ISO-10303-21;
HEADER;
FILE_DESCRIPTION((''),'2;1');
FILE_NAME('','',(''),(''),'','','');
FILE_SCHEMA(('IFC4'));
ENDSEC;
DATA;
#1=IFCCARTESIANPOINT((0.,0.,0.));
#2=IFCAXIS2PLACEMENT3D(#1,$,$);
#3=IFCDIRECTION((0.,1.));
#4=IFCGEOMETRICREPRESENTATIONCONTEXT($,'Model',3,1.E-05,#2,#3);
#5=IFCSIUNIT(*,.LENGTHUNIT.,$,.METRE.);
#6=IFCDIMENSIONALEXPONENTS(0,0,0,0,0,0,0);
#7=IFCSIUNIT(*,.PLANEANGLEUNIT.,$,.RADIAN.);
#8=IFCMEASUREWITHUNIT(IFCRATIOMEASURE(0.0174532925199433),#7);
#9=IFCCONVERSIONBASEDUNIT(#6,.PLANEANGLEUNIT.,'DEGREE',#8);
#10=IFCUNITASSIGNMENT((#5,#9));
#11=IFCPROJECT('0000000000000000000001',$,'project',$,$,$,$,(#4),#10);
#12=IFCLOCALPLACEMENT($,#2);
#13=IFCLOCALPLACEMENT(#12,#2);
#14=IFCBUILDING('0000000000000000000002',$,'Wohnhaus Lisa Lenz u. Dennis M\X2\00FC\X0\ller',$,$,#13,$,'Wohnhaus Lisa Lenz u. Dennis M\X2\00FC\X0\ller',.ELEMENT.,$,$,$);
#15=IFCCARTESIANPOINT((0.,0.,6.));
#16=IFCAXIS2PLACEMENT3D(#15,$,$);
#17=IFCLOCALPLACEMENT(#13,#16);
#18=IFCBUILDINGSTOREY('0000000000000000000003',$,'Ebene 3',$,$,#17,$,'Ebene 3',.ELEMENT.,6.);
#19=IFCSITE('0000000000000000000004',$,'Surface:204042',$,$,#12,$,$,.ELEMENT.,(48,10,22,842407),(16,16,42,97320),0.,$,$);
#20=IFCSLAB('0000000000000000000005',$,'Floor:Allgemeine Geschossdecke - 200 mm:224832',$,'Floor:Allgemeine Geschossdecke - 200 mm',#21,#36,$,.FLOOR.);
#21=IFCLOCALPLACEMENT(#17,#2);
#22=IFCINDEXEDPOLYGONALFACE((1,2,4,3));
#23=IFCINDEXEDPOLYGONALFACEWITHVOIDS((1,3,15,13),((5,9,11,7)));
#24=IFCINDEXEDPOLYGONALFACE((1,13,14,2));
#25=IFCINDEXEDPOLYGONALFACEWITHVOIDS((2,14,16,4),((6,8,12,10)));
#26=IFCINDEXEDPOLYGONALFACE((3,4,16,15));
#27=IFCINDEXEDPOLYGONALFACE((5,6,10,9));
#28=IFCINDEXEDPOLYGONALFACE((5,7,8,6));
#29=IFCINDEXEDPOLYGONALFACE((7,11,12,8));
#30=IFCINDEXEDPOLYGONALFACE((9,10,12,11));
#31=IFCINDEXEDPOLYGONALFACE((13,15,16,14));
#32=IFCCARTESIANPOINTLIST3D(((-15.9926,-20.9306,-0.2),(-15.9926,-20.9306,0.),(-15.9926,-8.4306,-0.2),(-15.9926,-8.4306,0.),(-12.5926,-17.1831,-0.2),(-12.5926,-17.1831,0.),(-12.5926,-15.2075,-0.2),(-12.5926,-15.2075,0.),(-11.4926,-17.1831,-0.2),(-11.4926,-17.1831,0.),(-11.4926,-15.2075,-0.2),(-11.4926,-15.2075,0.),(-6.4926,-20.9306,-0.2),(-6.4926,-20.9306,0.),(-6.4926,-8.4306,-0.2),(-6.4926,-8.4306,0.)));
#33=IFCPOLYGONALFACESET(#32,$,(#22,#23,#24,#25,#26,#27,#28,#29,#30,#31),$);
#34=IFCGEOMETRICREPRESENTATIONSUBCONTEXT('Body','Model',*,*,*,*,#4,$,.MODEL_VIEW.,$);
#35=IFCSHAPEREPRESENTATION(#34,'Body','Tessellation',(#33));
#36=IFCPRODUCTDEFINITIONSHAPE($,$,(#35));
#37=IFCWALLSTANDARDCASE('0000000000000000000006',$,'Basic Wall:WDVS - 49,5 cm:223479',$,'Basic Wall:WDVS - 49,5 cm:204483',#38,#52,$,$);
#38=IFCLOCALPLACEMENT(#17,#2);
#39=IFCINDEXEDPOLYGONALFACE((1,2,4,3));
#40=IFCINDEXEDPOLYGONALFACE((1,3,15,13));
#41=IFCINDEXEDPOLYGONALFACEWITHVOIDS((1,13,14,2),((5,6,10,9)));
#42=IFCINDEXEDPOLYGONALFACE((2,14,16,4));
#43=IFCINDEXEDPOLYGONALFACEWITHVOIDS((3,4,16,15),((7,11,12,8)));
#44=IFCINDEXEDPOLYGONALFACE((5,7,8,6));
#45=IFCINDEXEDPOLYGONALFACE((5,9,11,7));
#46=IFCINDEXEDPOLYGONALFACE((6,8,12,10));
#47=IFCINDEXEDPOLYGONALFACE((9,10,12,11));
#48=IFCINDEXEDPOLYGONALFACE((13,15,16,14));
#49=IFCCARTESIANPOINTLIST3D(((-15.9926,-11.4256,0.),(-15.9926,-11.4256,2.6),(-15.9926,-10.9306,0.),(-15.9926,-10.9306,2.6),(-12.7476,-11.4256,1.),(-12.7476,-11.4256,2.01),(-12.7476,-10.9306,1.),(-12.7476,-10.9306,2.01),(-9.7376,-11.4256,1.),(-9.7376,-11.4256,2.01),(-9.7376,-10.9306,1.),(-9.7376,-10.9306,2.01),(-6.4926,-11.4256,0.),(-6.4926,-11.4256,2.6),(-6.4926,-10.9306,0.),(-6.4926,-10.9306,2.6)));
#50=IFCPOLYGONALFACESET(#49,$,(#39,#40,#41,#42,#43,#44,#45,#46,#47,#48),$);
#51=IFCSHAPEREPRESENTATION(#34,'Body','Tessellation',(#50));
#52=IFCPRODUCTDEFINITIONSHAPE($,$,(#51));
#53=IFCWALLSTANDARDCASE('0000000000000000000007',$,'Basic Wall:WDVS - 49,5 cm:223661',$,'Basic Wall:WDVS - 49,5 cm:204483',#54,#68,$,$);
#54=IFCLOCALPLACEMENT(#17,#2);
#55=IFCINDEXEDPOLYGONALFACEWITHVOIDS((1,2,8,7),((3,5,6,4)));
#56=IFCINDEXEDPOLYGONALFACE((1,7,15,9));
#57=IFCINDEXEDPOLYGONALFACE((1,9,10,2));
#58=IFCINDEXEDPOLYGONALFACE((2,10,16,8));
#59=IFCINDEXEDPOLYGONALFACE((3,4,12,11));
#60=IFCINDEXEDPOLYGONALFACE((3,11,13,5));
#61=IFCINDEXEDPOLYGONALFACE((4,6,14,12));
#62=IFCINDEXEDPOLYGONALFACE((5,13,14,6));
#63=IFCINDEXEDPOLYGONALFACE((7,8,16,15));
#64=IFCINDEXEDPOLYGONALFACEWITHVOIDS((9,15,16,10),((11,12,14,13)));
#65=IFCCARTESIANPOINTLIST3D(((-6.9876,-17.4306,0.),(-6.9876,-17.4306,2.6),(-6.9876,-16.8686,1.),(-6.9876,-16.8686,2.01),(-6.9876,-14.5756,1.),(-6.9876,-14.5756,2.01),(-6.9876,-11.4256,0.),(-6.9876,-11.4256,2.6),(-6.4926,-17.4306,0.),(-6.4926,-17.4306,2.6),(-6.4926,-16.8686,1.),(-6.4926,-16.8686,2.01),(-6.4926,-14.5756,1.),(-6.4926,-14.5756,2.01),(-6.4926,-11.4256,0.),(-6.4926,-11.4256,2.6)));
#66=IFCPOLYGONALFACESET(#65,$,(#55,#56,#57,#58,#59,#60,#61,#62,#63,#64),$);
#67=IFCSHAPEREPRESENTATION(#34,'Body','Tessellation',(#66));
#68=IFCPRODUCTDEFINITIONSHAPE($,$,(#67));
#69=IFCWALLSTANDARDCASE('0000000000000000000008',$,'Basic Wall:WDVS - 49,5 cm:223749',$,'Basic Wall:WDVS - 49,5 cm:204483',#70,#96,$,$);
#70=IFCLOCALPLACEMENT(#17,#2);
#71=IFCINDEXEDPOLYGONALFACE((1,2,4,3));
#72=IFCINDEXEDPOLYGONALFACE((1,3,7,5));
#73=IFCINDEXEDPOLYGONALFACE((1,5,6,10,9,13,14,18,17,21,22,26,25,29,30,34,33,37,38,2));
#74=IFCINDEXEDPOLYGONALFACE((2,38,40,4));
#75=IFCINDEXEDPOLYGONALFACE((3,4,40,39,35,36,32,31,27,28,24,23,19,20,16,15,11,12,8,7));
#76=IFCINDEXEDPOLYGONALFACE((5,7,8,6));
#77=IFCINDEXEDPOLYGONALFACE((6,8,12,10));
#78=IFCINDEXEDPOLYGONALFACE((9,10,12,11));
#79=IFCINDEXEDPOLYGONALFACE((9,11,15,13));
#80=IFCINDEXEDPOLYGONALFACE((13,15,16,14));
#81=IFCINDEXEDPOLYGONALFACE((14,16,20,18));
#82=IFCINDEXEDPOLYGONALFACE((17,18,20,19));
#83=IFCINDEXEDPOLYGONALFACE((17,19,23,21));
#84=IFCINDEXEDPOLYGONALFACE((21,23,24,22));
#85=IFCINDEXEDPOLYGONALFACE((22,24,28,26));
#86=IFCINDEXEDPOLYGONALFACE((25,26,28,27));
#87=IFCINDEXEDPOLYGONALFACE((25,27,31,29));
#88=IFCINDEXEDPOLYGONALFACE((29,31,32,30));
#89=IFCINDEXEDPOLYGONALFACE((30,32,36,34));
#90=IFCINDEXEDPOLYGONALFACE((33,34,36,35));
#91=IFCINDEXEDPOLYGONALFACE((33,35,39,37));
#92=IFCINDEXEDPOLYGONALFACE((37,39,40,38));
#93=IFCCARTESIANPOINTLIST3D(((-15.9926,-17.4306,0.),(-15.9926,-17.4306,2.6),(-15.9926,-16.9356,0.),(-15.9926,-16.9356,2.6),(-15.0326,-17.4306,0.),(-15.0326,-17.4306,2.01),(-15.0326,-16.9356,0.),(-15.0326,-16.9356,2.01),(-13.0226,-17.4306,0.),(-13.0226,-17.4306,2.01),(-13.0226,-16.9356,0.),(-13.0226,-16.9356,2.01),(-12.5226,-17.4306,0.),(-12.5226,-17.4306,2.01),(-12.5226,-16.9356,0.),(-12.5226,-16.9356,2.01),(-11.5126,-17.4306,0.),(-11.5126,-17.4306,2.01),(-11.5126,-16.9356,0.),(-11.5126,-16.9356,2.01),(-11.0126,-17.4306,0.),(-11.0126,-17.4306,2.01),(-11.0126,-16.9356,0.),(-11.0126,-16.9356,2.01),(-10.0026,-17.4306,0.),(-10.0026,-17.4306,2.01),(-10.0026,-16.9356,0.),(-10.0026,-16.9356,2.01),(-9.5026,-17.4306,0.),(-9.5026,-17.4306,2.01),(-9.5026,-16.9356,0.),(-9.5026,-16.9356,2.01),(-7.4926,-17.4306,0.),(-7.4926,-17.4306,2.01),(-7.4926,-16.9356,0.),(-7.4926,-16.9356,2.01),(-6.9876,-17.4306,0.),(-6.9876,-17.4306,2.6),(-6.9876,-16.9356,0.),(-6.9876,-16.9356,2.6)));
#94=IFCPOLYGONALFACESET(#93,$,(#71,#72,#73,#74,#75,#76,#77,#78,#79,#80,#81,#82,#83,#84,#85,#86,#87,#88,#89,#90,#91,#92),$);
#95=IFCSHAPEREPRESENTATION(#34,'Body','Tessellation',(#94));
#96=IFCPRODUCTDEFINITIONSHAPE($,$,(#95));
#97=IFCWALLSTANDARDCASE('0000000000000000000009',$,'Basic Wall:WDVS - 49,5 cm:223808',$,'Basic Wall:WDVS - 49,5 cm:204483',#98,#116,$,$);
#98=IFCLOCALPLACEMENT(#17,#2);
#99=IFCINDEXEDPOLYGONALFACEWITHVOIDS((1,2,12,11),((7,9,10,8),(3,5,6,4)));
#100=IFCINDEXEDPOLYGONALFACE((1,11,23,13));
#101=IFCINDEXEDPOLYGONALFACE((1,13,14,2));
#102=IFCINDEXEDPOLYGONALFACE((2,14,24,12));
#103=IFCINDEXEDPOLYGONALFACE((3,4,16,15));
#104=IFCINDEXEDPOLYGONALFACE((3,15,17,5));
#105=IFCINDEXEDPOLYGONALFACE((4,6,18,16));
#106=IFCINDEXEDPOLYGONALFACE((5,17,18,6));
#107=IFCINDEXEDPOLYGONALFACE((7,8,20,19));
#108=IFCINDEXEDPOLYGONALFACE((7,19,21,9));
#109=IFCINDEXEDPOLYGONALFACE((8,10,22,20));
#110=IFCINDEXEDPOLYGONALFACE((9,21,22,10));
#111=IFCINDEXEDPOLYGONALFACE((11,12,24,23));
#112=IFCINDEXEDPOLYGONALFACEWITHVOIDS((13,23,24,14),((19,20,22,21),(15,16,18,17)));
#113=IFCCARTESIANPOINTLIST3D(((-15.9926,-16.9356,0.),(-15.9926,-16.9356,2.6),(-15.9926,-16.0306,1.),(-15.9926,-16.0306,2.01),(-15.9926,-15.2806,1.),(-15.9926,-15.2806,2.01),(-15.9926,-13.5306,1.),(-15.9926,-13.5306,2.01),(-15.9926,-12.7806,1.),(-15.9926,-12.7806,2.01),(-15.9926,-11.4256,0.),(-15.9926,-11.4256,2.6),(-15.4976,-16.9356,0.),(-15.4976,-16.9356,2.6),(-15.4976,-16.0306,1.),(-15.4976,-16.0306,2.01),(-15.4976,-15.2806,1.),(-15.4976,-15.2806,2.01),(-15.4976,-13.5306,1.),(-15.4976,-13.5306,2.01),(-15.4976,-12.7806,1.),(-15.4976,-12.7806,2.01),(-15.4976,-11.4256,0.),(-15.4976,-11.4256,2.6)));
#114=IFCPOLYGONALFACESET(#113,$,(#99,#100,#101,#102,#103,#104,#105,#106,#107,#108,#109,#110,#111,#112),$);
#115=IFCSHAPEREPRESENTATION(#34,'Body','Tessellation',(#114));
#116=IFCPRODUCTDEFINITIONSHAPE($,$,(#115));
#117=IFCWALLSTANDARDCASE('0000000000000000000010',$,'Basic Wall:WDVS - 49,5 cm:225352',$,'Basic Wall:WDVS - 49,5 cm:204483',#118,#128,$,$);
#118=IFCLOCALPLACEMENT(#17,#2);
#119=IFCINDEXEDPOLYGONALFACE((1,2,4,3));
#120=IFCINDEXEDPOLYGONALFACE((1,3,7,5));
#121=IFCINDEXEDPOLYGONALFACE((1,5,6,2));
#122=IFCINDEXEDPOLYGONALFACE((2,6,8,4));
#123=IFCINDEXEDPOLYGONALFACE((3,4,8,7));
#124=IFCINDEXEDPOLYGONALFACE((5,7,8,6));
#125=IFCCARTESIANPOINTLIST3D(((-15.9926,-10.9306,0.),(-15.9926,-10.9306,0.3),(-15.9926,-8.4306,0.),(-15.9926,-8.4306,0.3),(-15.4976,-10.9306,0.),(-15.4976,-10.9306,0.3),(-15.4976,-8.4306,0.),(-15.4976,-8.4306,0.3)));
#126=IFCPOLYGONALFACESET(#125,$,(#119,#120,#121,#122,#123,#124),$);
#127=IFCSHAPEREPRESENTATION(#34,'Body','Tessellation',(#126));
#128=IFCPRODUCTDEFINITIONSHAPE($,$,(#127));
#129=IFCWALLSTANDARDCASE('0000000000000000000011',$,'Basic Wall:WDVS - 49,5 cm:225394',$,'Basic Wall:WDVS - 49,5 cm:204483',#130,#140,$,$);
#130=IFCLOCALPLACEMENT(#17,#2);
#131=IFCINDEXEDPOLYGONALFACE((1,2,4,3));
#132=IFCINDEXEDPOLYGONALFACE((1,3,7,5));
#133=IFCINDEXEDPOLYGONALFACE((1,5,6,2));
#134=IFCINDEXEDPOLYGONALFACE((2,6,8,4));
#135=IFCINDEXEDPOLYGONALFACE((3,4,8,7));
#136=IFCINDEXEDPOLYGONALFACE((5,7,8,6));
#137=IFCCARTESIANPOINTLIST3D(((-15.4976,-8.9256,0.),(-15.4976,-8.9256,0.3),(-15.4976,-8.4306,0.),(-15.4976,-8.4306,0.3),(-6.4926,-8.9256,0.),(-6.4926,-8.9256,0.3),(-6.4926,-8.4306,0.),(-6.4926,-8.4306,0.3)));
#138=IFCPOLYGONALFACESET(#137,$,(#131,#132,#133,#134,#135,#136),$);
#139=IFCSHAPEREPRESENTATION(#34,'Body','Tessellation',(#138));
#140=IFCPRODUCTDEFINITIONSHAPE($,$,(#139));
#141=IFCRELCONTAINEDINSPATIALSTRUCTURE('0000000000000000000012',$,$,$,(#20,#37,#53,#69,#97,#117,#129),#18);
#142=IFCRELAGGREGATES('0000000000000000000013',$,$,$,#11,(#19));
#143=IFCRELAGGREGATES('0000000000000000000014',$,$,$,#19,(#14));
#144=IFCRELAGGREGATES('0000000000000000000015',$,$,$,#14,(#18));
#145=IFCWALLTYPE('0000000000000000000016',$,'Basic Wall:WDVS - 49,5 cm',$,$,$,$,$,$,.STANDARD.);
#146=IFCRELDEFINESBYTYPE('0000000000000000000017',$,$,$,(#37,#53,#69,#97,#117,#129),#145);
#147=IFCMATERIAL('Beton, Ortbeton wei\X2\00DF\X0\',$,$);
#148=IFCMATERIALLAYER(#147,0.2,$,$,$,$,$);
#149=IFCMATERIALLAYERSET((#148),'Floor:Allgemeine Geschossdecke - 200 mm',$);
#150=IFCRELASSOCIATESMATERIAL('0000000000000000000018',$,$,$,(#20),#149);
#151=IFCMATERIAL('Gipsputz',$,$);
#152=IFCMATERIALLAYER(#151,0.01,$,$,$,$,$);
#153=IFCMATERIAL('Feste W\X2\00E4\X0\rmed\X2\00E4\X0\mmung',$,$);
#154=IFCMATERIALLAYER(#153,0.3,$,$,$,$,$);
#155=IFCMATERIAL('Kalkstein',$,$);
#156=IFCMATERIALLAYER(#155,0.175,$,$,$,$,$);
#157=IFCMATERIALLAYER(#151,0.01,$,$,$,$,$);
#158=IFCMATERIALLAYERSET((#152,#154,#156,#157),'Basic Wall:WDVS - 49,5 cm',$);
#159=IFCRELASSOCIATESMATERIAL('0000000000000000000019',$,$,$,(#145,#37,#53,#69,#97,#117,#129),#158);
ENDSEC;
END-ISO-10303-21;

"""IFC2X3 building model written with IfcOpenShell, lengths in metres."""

from ifc_helpers import new_model, entity, si_unit, converted_unit, direction, frame, frame_2d, origin, origin_2d_with_axis, place, context, subcontext, project, spatial, polyline, rectangle, extrude, clip, bounded_halfspace, material, layer, layer_set, layer_usage, type_object, element, save


model = new_model("IFC2X3")

# Units and contexts
model_context = context("Model", 3, precision=1e-05, world=origin(), true_north=direction((0.0, 1.0)))
body_context = subcontext(model_context, "Body", "Model", "MODEL_VIEW")
ifc_project = project(units=[si_unit("LENGTHUNIT", "METRE"), converted_unit("PLANEANGLEUNIT", "DEGREE", entity("IfcRatioMeasure", 0.0174532925199433), si_unit("PLANEANGLEUNIT", "RADIAN"), dimensions=[0, 0, 0, 0, 0, 0, 0])], contexts=[model_context])

# Site, building, storey
site_placement = place(None, origin())
site = spatial("IfcSite", under=ifc_project, at=site_placement, Name="Surface:204042", CompositionType="ELEMENT", RefLatitude=(48, 10, 22, 842407), RefLongitude=(16, 16, 42, 97320), RefElevation=0.0)
building_placement = place(site_placement, origin())
building = spatial("IfcBuilding", under=site, at=building_placement, Name="Wohnhaus Lisa Lenz u. Dennis Müller", LongName="Wohnhaus Lisa Lenz u. Dennis Müller", CompositionType="ELEMENT")
storey_placement = place(building_placement, frame((0.0, 0.0, 6.0)))
storey = spatial("IfcBuildingStorey", under=building, at=storey_placement, Name="Ebene 3", LongName="Ebene 3", CompositionType="ELEMENT", Elevation=6.0)

# Slab, opening
ifc_material_1 = material(Name="Beton, Ortbeton weiß")
ifc_layer_1 = layer(ifc_material_1, 0.2)
ifc_layer_set_1 = layer_set([ifc_layer_1], Name="Floor:Allgemeine Geschossdecke - 200 mm")
ifc_layer_usage_1 = layer_usage(ifc_layer_set_1, "AXIS3", "POSITIVE", 0.0)
slab_placement = place(storey_placement, frame((-15.9926, -20.9306, -0.2)))
slab = element("IfcSlab", 1, at=slab_placement, inside=storey, material=ifc_layer_usage_1, Name="Floor:Allgemeine Geschossdecke - 200 mm:224832", ObjectType="Floor:Allgemeine Geschossdecke - 200 mm", PredefinedType="FLOOR", context=body_context, shape_type="SweptSolid", body=[
    extrude(rectangle(XDim=12.5, YDim=9.5, at=frame_2d((0.0, 0.0), x_axis=(0.0, -1.0))), frame((4.75, 6.25, 0.2), z_axis=(0.0, 0.0, -1.0), x_axis=(-1.0, 0.0, 0.0)), (0.0, 0.0, 1.0), 0.2),
])
opening_1_placement = place(slab_placement, frame((3.95, 4.7353, 0.2)))
element("IfcOpeningElement", 2, at=opening_1_placement, cuts=slab, ObjectType="Opening", context=body_context, shape_type="SweptSolid", body=[
    extrude(rectangle(XDim=1.9756, YDim=1.1, at=origin_2d_with_axis()), frame((0.0, 0.0, 0.0), z_axis=(0.0, 0.0, -1.0), x_axis=(0.0, -1.0, 0.0)), (0.0, 0.0, 1.0), 0.2),
])

# Walls, openings
ifc_material_2 = material(Name="Gipsputz")
ifc_layer_2 = layer(ifc_material_2, 0.01)
ifc_material_3 = material(Name="Feste Wärmedämmung")
ifc_layer_3 = layer(ifc_material_3, 0.3)
ifc_material_4 = material(Name="Kalkstein")
ifc_layer_4 = layer(ifc_material_4, 0.175)
ifc_layer_5 = layer(ifc_material_2, 0.01)
ifc_layer_set_2 = layer_set([ifc_layer_2, ifc_layer_3, ifc_layer_4, ifc_layer_5], Name="Basic Wall:WDVS - 49,5 cm")
ifc_layer_usage_2 = layer_usage(ifc_layer_set_2, "AXIS2", "NEGATIVE", 0.2475)
wall_type_1 = type_object("IfcWallType", Name="Basic Wall:WDVS - 49,5 cm", PredefinedType="STANDARD", material=ifc_layer_set_2)
wall_1_placement = place(storey_placement, frame((-6.4926, -11.1781, 0.0), z_axis=(0.0, 0.0, 1.0), x_axis=(-1.0, 0.0, 0.0)))
wall_1 = element("IfcWallStandardCase", 3, at=wall_1_placement, inside=storey, type_object=wall_type_1, material=ifc_layer_usage_2, Name="Basic Wall:WDVS - 49,5 cm:223479", ObjectType="Basic Wall:WDVS - 49,5 cm:204483", context=body_context, shape_type="Clipping", body=[
    clip(extrude(rectangle(XDim=9.5, YDim=0.495, at=frame_2d((4.75, 0.0), x_axis=(-1.0, 0.0))), origin(), (0.0, 0.0, 1.0), 2.6), bounded_halfspace(frame((0.0, -0.2475, 2.6), z_axis=(0.0, 0.0, -1.0), x_axis=(0.0, 1.0, 0.0)), True, frame((0.0, -0.2475, 2.6)), polyline([(0.0, 0.0), (9.5, 0.0), (9.5, 0.495), (9.005, 0.495), (0.495, 0.495), (0.0, 0.495), (0.0, 0.0)]))),
])
opening_2_placement = place(wall_1_placement, frame((6.255, 0.2475, 1.0)))
element("IfcOpeningElement", 4, at=opening_2_placement, cuts=wall_1, ObjectType="Opening", context=body_context, shape_type="SweptSolid", body=[
    extrude(rectangle(XDim=1.01, YDim=3.01, at=frame_2d((0.505, 1.505), x_axis=(1.0, 0.0))), frame((0.0, 0.0, 0.0), z_axis=(0.0, -1.0, 0.0), x_axis=(0.0, 0.0, 1.0)), (0.0, 0.0, 1.0), 0.495),
])
ifc_layer_usage_3 = layer_usage(ifc_layer_set_2, "AXIS2", "NEGATIVE", 0.2475)
wall_2_placement = place(storey_placement, frame((-6.7401, -11.4256, 0.0), z_axis=(0.0, 0.0, 1.0), x_axis=(0.0, -1.0, 0.0)))
wall_2 = element("IfcWallStandardCase", 5, at=wall_2_placement, inside=storey, type_object=wall_type_1, material=ifc_layer_usage_3, Name="Basic Wall:WDVS - 49,5 cm:223661", ObjectType="Basic Wall:WDVS - 49,5 cm:204483", context=body_context, shape_type="Clipping", body=[
    clip(extrude(rectangle(XDim=6.005, YDim=0.495, at=frame_2d((3.0025, 0.0), x_axis=(-1.0, 0.0))), origin(), (0.0, 0.0, 1.0), 2.6), bounded_halfspace(frame((0.0, -0.2475, 2.6), z_axis=(0.0, 0.0, -1.0), x_axis=(1.0, 0.0, 0.0)), True, frame((0.0, -0.2475, 2.6)), polyline([(0.0, 0.0), (2.5, 0.0), (2.65, 0.0), (5.51, 0.0), (6.005, 0.0), (6.005, 0.495), (0.0, 0.495), (0.0, 0.0)]))),
])
opening_3_placement = place(wall_2_placement, frame((3.15, -0.2475, 1.0)))
element("IfcOpeningElement", 6, at=opening_3_placement, cuts=wall_2, ObjectType="Opening", context=body_context, shape_type="SweptSolid", body=[
    extrude(rectangle(XDim=1.01, YDim=2.2931, at=frame_2d((0.505, 1.1465), x_axis=(1.0, 0.0))), frame((0.0, 0.0, 0.0), z_axis=(0.0, 1.0, 0.0), x_axis=(0.0, 0.0, 1.0)), (0.0, 0.0, 1.0), 0.495),
])

# Walls, openings
ifc_layer_usage_4 = layer_usage(ifc_layer_set_2, "AXIS2", "NEGATIVE", 0.2475)
wall_3_placement = place(storey_placement, frame((-6.9876, -17.1831, 0.0), z_axis=(0.0, 0.0, 1.0), x_axis=(-1.0, 0.0, 0.0)))
wall_3 = element("IfcWallStandardCase", 7, at=wall_3_placement, inside=storey, type_object=wall_type_1, material=ifc_layer_usage_4, Name="Basic Wall:WDVS - 49,5 cm:223749", ObjectType="Basic Wall:WDVS - 49,5 cm:204483", context=body_context, shape_type="Clipping", body=[
    clip(extrude(rectangle(XDim=9.005, YDim=0.495, at=frame_2d((4.5025, 0.0), x_axis=(-1.0, 0.0))), origin(), (0.0, 0.0, 1.0), 2.6), bounded_halfspace(frame((0.0, -0.2475, 2.6), z_axis=(0.0, 0.0, -1.0), x_axis=(0.0, 1.0, 0.0)), True, frame((0.0, -0.2475, 2.6)), polyline([(0.0, 0.0), (8.51, 0.0), (9.005, 0.0), (9.005, 0.495), (0.0, 0.495), (0.0, 0.0)]))),
])
opening_4_placement = place(wall_3_placement, frame((8.045, 0.2475, 0.0)))
element("IfcOpeningElement", 8, at=opening_4_placement, cuts=wall_3, ObjectType="Opening", context=body_context, shape_type="SweptSolid", body=[
    extrude(rectangle(XDim=2.01, YDim=2.01, at=frame_2d((1.005, 1.005), x_axis=(1.0, 0.0))), frame((0.0, 0.0, 0.0), z_axis=(0.0, -1.0, 0.0), x_axis=(0.0, 0.0, 1.0)), (0.0, 0.0, 1.0), 0.495),
])
opening_5_placement = place(wall_3_placement, frame((5.535, 0.2475, 0.0)))
element("IfcOpeningElement", 9, at=opening_5_placement, cuts=wall_3, ObjectType="Opening", context=body_context, shape_type="SweptSolid", body=[
    extrude(rectangle(XDim=2.01, YDim=1.01, at=frame_2d((1.005, 0.505), x_axis=(1.0, 0.0))), frame((0.0, 0.0, 0.0), z_axis=(0.0, -1.0, 0.0), x_axis=(0.0, 0.0, 1.0)), (0.0, 0.0, 1.0), 0.495),
])
opening_6_placement = place(wall_3_placement, frame((4.025, 0.2475, 0.0)))
element("IfcOpeningElement", 10, at=opening_6_placement, cuts=wall_3, ObjectType="Opening", context=body_context, shape_type="SweptSolid", body=[
    extrude(rectangle(XDim=2.01, YDim=1.01, at=frame_2d((1.005, 0.505), x_axis=(1.0, 0.0))), frame((0.0, 0.0, 0.0), z_axis=(0.0, -1.0, 0.0), x_axis=(0.0, 0.0, 1.0)), (0.0, 0.0, 1.0), 0.495),
])
opening_7_placement = place(wall_3_placement, frame((2.515, 0.2475, 0.0)))
element("IfcOpeningElement", 11, at=opening_7_placement, cuts=wall_3, ObjectType="Opening", context=body_context, shape_type="SweptSolid", body=[
    extrude(rectangle(XDim=2.01, YDim=2.01, at=frame_2d((1.005, 1.005), x_axis=(1.0, 0.0))), frame((0.0, 0.0, 0.0), z_axis=(0.0, -1.0, 0.0), x_axis=(0.0, 0.0, 1.0)), (0.0, 0.0, 1.0), 0.495),
])
ifc_layer_usage_5 = layer_usage(ifc_layer_set_2, "AXIS2", "NEGATIVE", 0.2475)
wall_4_placement = place(storey_placement, frame((-15.7451, -16.9356, 0.0), z_axis=(0.0, 0.0, 1.0), x_axis=(0.0, 1.0, 0.0)))
wall_4 = element("IfcWallStandardCase", 12, at=wall_4_placement, inside=storey, type_object=wall_type_1, material=ifc_layer_usage_5, Name="Basic Wall:WDVS - 49,5 cm:223808", ObjectType="Basic Wall:WDVS - 49,5 cm:204483", context=body_context, shape_type="Clipping", body=[
    clip(extrude(rectangle(XDim=5.51, YDim=0.495, at=frame_2d((2.755, 0.0), x_axis=(-1.0, 0.0))), origin(), (0.0, 0.0, 1.0), 2.6), bounded_halfspace(frame((0.0, -0.2475, 2.6), z_axis=(0.0, 0.0, -1.0), x_axis=(-1.0, 0.0, 0.0)), True, frame((0.0, -0.2475, 2.6)), polyline([(0.0, 0.0), (5.51, 0.0), (5.51, 0.495), (0.0, 0.495), (0.0, 0.0)]))),
])
opening_8_placement = place(wall_4_placement, frame((4.155, 0.2475, 1.0)))
element("IfcOpeningElement", 13, at=opening_8_placement, cuts=wall_4, ObjectType="Opening", context=body_context, shape_type="SweptSolid", body=[
    extrude(rectangle(XDim=1.01, YDim=0.75, at=frame_2d((0.505, 0.375), x_axis=(1.0, 0.0))), frame((0.0, 0.0, 0.0), z_axis=(0.0, -1.0, 0.0), x_axis=(0.0, 0.0, 1.0)), (0.0, 0.0, 1.0), 0.495),
])
opening_9_placement = place(wall_4_placement, frame((0.905, -0.2475, 1.0)))
element("IfcOpeningElement", 14, at=opening_9_placement, cuts=wall_4, ObjectType="Opening", context=body_context, shape_type="SweptSolid", body=[
    extrude(rectangle(XDim=1.01, YDim=0.75, at=frame_2d((0.505, 0.375), x_axis=(1.0, 0.0))), frame((0.0, 0.0, 0.0), z_axis=(0.0, 1.0, 0.0), x_axis=(0.0, 0.0, 1.0)), (0.0, 0.0, 1.0), 0.495),
])

# Walls
ifc_layer_usage_6 = layer_usage(ifc_layer_set_2, "AXIS2", "NEGATIVE", 0.2475)
wall_5_placement = place(storey_placement, frame((-15.7451, -10.9306, 0.0), z_axis=(0.0, 0.0, 1.0), x_axis=(0.0, 1.0, 0.0)))
element("IfcWallStandardCase", 15, at=wall_5_placement, inside=storey, type_object=wall_type_1, material=ifc_layer_usage_6, Name="Basic Wall:WDVS - 49,5 cm:225352", ObjectType="Basic Wall:WDVS - 49,5 cm:204483", context=body_context, shape_type="SweptSolid", body=[
    extrude(rectangle(XDim=2.5, YDim=0.495, at=frame_2d((1.25, 0.0), x_axis=(-1.0, 0.0))), origin(), (0.0, 0.0, 1.0), 0.3),
])
ifc_layer_usage_7 = layer_usage(ifc_layer_set_2, "AXIS2", "NEGATIVE", 0.2475)
wall_6_placement = place(storey_placement, frame((-15.4976, -8.6781, 0.0)))
element("IfcWallStandardCase", 16, at=wall_6_placement, inside=storey, type_object=wall_type_1, material=ifc_layer_usage_7, Name="Basic Wall:WDVS - 49,5 cm:225394", ObjectType="Basic Wall:WDVS - 49,5 cm:204483", context=body_context, shape_type="SweptSolid", body=[
    extrude(rectangle(XDim=9.005, YDim=0.495, at=frame_2d((4.5025, 0.0), x_axis=(-1.0, 0.0))), origin(), (0.0, 0.0, 1.0), 0.3),
])

save(model, "model.ifc")
